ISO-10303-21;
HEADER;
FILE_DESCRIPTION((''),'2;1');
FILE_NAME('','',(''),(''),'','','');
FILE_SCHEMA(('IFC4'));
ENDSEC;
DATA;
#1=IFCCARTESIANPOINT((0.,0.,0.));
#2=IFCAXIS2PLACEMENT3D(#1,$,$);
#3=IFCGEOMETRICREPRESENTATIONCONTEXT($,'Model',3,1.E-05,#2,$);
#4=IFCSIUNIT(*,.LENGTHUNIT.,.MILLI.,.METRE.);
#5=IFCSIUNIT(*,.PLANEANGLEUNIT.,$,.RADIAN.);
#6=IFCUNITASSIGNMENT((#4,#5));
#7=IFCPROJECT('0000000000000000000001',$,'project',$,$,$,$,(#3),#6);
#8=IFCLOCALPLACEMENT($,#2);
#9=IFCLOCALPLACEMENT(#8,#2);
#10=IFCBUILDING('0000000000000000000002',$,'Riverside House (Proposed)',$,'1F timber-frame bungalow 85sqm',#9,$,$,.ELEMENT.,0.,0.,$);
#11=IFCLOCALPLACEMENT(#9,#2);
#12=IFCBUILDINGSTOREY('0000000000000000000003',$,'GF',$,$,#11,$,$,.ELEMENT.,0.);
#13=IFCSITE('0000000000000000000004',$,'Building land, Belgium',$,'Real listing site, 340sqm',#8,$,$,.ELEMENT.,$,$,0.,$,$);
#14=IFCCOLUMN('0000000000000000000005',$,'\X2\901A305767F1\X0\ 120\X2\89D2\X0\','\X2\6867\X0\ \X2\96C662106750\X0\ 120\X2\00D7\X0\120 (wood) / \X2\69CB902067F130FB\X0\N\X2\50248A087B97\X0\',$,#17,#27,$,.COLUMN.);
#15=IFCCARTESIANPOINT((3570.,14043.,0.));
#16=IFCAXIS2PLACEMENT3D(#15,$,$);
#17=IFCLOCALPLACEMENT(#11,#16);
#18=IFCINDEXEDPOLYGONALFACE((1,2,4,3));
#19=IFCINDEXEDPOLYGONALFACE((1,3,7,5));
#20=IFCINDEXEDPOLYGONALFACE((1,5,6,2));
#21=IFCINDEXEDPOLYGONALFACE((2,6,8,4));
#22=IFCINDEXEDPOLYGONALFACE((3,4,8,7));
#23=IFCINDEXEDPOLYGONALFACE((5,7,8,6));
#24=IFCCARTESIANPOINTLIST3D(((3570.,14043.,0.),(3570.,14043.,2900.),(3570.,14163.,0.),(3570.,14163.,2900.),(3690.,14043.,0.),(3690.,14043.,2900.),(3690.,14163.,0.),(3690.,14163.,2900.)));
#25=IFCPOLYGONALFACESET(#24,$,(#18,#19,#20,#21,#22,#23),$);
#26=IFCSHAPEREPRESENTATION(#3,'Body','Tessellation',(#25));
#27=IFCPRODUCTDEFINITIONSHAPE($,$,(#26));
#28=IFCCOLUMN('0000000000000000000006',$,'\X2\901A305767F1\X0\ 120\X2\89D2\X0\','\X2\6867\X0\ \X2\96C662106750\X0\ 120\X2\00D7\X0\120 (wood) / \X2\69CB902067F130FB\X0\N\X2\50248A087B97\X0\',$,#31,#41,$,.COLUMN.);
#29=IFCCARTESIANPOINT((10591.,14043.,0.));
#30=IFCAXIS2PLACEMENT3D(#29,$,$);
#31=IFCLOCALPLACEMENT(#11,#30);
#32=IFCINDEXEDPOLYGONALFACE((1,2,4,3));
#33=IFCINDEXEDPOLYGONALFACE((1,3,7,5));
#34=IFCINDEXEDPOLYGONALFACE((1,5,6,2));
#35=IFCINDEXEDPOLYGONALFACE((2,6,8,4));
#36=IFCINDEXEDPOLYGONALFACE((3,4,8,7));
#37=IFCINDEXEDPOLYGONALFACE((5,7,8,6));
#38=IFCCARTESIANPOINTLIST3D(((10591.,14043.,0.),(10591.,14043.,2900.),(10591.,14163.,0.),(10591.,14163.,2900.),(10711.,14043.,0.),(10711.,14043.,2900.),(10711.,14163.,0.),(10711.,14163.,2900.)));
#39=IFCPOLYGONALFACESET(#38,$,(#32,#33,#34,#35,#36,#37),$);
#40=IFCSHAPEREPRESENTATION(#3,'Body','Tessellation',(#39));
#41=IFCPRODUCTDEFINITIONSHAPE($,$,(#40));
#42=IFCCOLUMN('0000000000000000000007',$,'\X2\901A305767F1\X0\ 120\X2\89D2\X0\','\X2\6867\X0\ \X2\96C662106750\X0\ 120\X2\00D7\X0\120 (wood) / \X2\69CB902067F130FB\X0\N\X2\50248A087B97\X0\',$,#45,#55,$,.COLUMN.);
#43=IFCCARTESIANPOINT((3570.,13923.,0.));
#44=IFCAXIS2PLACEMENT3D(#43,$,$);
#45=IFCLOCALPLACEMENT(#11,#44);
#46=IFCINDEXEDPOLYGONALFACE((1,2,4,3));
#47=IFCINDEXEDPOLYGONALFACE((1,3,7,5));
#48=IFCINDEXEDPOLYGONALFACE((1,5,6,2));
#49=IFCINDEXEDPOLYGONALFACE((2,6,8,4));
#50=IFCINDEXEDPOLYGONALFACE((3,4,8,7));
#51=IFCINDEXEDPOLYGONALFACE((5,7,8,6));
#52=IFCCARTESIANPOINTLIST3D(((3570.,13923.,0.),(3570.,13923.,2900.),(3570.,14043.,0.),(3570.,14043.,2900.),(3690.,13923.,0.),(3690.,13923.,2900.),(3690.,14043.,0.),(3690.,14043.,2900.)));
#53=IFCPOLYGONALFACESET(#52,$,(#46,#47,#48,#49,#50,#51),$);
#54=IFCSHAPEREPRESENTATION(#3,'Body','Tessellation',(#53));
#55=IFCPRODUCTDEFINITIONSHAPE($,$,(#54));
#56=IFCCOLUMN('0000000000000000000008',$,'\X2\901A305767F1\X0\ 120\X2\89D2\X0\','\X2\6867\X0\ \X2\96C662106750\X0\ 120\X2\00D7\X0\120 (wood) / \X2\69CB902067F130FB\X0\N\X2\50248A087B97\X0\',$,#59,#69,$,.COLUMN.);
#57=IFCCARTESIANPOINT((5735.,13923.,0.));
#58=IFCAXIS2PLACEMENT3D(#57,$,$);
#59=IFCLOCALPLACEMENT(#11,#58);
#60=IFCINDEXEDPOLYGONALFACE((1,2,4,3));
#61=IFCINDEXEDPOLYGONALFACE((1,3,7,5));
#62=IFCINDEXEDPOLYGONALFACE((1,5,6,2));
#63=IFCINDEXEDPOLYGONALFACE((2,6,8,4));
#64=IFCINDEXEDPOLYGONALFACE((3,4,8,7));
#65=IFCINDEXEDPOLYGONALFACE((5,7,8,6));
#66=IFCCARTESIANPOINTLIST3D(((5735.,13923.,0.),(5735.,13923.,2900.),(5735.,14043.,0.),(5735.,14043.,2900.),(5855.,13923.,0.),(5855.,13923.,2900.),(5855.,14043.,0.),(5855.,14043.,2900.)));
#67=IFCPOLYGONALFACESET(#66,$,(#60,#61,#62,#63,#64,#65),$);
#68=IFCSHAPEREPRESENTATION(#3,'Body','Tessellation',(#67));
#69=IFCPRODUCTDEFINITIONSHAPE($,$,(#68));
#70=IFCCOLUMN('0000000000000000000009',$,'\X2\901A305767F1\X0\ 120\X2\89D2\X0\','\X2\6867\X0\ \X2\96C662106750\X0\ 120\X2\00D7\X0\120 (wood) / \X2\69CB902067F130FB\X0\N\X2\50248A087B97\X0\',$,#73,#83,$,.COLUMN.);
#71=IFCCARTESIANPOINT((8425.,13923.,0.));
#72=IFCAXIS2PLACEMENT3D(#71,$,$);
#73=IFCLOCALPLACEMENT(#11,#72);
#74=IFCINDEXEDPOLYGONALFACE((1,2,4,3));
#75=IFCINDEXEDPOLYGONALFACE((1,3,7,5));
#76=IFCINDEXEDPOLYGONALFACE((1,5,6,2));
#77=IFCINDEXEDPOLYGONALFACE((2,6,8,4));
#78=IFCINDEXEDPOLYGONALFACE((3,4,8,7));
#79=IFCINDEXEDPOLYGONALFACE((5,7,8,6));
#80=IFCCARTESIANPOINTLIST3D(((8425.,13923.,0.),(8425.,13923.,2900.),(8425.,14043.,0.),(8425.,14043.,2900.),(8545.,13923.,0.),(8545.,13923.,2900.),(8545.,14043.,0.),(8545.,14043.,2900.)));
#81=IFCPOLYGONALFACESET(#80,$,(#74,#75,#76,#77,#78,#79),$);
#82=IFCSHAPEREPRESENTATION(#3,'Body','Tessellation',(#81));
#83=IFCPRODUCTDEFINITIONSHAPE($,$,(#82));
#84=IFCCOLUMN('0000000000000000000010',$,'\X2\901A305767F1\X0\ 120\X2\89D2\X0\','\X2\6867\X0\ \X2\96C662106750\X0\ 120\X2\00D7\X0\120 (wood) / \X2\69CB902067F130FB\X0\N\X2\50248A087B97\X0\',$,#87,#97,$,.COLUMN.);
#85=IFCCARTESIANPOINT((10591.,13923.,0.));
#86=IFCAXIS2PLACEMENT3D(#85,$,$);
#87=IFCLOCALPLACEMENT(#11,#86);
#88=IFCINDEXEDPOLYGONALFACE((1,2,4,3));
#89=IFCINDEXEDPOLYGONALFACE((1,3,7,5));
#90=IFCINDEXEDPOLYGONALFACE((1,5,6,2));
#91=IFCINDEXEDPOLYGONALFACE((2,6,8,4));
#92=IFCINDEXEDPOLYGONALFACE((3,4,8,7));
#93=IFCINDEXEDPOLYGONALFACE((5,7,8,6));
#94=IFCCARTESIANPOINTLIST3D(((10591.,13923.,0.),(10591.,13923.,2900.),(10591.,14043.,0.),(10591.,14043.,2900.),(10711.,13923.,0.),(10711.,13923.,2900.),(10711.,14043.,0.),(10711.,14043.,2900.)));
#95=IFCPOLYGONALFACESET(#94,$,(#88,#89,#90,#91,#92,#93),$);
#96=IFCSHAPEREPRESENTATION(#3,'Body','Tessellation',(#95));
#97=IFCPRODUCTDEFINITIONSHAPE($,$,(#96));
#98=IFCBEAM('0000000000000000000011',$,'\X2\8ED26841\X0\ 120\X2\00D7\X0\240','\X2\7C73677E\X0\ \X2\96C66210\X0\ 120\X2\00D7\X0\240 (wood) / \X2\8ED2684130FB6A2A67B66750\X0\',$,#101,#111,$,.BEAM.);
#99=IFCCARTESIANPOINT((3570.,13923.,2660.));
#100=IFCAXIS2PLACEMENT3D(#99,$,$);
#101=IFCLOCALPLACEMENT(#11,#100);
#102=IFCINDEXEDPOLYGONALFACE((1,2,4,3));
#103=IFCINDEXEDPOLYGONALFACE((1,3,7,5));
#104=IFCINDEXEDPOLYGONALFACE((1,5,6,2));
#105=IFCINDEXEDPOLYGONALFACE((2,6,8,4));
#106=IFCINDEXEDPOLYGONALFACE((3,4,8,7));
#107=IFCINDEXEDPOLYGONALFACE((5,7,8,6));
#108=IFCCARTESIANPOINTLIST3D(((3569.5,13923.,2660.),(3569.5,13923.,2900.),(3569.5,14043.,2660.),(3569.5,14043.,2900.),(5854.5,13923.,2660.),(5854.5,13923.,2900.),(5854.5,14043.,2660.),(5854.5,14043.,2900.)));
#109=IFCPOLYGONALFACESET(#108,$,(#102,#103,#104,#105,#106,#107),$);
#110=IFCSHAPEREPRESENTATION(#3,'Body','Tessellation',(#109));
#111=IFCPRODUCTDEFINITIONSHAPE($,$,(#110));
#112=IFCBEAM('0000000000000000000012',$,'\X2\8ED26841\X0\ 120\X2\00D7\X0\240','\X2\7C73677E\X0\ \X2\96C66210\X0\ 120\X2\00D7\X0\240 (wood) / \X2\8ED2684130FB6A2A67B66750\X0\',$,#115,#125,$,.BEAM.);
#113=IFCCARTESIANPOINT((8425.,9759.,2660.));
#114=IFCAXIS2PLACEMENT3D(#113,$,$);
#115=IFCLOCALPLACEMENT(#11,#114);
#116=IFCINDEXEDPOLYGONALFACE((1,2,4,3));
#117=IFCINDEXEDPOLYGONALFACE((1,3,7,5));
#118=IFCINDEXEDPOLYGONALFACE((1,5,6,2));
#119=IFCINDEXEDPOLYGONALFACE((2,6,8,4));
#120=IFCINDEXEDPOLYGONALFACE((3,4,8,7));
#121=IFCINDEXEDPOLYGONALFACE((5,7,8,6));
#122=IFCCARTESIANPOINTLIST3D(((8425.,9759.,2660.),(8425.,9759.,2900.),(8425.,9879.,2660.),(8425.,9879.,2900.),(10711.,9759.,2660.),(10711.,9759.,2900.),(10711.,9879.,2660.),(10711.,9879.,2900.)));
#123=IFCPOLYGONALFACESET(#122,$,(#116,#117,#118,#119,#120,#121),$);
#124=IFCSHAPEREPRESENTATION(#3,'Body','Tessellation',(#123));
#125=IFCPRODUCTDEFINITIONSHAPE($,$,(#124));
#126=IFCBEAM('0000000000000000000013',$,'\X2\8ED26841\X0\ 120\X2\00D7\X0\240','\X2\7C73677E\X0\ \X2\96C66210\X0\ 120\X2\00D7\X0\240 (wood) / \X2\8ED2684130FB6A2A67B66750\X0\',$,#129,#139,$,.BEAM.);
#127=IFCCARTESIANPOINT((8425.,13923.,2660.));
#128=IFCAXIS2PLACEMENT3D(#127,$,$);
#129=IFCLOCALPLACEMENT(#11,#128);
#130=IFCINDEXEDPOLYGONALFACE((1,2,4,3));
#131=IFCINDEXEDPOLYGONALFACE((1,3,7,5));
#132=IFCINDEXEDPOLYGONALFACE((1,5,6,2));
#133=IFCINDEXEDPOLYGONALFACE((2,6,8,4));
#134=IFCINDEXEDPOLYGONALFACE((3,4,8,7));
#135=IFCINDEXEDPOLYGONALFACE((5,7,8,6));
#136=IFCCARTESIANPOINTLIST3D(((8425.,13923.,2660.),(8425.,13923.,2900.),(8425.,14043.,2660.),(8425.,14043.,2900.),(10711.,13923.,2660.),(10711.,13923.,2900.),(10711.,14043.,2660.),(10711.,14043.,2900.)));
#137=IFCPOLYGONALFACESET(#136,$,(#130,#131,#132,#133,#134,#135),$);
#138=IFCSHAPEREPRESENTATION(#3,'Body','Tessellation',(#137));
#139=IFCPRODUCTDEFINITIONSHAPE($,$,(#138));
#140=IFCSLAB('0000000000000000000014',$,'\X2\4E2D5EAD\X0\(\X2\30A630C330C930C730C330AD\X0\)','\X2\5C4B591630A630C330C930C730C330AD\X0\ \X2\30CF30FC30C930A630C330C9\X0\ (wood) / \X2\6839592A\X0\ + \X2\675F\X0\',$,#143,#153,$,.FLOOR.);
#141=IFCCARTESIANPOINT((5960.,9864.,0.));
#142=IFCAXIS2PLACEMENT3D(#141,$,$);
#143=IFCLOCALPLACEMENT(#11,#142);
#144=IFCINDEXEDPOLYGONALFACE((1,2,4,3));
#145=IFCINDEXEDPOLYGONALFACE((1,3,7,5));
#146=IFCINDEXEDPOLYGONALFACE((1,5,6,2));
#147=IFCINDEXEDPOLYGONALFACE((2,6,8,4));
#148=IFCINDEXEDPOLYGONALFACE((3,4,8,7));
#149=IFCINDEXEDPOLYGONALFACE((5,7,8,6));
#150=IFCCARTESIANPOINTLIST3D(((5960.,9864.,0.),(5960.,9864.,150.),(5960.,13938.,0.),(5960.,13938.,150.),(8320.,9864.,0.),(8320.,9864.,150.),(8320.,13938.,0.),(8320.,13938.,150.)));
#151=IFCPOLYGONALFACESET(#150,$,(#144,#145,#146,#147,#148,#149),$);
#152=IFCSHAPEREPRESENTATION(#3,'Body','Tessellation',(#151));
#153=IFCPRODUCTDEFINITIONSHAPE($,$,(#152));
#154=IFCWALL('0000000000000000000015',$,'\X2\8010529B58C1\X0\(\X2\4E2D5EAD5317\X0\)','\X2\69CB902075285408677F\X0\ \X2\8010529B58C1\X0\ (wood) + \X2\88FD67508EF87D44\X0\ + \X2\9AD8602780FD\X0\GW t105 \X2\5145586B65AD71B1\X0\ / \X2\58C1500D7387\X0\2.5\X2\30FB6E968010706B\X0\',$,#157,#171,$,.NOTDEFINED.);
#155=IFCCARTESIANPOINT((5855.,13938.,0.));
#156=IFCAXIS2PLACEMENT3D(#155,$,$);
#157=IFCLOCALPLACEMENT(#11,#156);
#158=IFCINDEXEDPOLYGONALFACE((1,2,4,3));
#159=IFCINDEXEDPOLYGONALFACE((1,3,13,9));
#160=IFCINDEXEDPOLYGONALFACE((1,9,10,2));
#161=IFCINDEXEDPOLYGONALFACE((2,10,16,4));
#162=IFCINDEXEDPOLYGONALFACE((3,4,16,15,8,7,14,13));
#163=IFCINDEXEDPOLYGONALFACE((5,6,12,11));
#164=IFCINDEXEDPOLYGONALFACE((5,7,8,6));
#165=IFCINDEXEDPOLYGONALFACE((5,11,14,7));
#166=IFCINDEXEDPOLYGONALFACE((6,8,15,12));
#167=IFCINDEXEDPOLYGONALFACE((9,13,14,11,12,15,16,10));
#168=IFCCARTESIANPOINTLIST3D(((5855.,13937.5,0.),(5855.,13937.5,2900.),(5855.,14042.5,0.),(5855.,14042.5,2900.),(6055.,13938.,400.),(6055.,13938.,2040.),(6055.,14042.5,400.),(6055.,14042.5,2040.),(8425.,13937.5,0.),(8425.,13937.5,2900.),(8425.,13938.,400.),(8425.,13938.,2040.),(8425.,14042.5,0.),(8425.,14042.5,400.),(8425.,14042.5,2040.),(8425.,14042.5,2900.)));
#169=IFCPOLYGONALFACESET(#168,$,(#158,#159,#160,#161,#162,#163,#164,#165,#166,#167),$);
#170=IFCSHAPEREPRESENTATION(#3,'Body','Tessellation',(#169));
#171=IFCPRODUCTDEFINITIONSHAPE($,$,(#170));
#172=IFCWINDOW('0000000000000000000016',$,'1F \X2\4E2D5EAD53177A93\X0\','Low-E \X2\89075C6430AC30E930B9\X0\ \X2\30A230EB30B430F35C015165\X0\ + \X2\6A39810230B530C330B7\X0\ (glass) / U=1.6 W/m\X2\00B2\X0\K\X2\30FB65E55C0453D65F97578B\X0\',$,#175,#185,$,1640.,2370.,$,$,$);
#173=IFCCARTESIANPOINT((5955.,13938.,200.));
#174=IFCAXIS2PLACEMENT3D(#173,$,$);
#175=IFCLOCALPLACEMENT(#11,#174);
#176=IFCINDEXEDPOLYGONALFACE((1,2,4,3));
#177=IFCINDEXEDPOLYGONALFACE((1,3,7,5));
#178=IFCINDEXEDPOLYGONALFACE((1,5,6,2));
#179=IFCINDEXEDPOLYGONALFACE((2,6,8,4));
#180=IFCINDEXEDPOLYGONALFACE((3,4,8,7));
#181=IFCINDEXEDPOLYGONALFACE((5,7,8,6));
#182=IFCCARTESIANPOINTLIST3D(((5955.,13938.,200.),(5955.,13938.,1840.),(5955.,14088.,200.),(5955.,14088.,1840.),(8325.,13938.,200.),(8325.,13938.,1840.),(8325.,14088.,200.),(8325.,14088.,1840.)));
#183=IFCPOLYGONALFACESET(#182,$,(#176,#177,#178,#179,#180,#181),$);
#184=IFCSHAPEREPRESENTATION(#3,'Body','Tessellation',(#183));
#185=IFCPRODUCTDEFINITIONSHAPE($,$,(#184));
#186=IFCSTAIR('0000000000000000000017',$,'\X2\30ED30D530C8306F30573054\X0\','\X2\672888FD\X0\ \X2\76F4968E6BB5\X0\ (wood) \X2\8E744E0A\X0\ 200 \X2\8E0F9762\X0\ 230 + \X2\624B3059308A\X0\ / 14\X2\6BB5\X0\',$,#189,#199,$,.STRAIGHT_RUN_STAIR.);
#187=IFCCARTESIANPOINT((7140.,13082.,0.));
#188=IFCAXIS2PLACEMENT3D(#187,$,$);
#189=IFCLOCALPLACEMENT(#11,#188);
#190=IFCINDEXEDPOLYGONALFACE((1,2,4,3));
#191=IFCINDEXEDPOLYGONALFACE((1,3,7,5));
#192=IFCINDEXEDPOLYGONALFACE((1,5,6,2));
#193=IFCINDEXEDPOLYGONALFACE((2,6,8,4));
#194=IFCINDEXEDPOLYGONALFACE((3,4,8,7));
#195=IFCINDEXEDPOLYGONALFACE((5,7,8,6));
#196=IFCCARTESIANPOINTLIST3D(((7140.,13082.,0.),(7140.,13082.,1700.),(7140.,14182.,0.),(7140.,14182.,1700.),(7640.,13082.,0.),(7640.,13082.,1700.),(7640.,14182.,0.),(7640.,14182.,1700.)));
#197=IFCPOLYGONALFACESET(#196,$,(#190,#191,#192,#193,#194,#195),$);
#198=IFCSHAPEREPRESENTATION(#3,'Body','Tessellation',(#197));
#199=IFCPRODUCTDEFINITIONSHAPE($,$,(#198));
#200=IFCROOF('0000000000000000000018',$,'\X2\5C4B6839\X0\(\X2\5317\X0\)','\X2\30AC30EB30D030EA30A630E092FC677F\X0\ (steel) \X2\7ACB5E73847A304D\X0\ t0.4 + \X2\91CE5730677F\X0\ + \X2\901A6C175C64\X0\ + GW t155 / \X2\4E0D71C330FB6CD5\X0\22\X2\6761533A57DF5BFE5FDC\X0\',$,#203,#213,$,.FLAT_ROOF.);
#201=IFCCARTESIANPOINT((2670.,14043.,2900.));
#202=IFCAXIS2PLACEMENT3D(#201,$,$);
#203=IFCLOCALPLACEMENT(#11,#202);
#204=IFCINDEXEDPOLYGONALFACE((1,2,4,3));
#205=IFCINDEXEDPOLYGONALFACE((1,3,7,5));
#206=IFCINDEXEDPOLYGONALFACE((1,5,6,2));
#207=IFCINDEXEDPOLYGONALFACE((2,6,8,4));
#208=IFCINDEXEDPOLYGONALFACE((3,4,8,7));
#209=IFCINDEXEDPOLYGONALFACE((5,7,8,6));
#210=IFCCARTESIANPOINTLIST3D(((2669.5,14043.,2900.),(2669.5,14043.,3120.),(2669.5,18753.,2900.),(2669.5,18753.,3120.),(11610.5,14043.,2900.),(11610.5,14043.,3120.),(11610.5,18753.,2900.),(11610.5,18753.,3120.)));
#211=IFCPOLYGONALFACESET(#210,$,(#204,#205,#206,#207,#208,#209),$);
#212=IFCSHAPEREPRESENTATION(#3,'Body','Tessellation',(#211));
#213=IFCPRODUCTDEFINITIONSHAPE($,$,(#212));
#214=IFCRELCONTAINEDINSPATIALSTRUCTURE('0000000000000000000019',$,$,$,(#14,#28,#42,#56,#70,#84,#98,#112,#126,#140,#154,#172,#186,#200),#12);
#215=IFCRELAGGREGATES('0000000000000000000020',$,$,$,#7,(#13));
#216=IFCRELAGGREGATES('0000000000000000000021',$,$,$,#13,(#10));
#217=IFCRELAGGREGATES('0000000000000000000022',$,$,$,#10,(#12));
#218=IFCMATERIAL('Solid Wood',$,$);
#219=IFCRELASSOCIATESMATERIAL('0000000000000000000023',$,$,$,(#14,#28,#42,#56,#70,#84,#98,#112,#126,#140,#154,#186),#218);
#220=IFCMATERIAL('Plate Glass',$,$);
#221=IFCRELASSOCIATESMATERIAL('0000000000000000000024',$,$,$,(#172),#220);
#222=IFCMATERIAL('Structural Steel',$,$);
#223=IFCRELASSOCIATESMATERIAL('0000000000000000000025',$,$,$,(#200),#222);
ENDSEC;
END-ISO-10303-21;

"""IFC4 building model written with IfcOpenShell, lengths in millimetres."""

from ifc_helpers import new_model, si_unit, frame, frame_2d, origin, place, context, project, spatial, rectangle, extrude, material, element, fill, save


model = new_model("IFC4")

# Units and contexts
model_context = context("Model", 3, precision=1e-05, world=origin())
ifc_project = project(units=[si_unit("LENGTHUNIT", "METRE", prefix="MILLI"), si_unit("PLANEANGLEUNIT", "RADIAN")], contexts=[model_context])

# Site, building, storey
site_placement = place(None, origin())
site = spatial("IfcSite", under=ifc_project, at=site_placement, Name="Building land, Belgium", ObjectType="Real listing site, 340sqm", CompositionType="ELEMENT", RefElevation=0.0)
building_placement = place(site_placement, origin())
building = spatial("IfcBuilding", under=site, at=building_placement, Name="Riverside House (Proposed)", ObjectType="1F timber-frame bungalow 85sqm", CompositionType="ELEMENT", ElevationOfRefHeight=0.0, ElevationOfTerrain=0.0)
storey_placement = place(building_placement, origin())
storey = spatial("IfcBuildingStorey", under=building, at=storey_placement, Name="GF", CompositionType="ELEMENT", Elevation=0.0)

# Columns
ifc_material_1 = material(Name="Solid Wood")
column_1_placement = place(storey_placement, frame((3570.0, 14043.0, 0.0)))
element("IfcColumn", 1, at=column_1_placement, inside=storey, material=ifc_material_1, Name="通し柱 120角", Description="桧 集成材 120×120 (wood) / 構造柱・N値計算", PredefinedType="COLUMN", context=model_context, shape_type="SweptSolid", body=[
    extrude(rectangle(XDim=120.0, YDim=120.0, at=frame_2d((60.0, 60.0))), frame((3570.0, 14043.0, 0.0)), (0.0, 0.0, 1.0), 2900.0),
])
column_2_placement = place(storey_placement, frame((10591.0, 14043.0, 0.0)))
element("IfcColumn", 2, at=column_2_placement, inside=storey, material=ifc_material_1, Name="通し柱 120角", Description="桧 集成材 120×120 (wood) / 構造柱・N値計算", PredefinedType="COLUMN", context=model_context, shape_type="SweptSolid", body=[
    extrude(rectangle(XDim=120.0, YDim=120.0, at=frame_2d((60.0, 60.0))), frame((10591.0, 14043.0, 0.0)), (0.0, 0.0, 1.0), 2900.0),
])
column_3_placement = place(storey_placement, frame((3570.0, 13923.0, 0.0)))
element("IfcColumn", 3, at=column_3_placement, inside=storey, material=ifc_material_1, Name="通し柱 120角", Description="桧 集成材 120×120 (wood) / 構造柱・N値計算", PredefinedType="COLUMN", context=model_context, shape_type="SweptSolid", body=[
    extrude(rectangle(XDim=120.0, YDim=120.0, at=frame_2d((60.0, 60.0))), frame((3570.0, 13923.0, 0.0)), (0.0, 0.0, 1.0), 2900.0),
])
column_4_placement = place(storey_placement, frame((5735.0, 13923.0, 0.0)))
element("IfcColumn", 4, at=column_4_placement, inside=storey, material=ifc_material_1, Name="通し柱 120角", Description="桧 集成材 120×120 (wood) / 構造柱・N値計算", PredefinedType="COLUMN", context=model_context, shape_type="SweptSolid", body=[
    extrude(rectangle(XDim=120.0, YDim=120.0, at=frame_2d((60.0, 60.0))), frame((5735.0, 13923.0, 0.0)), (0.0, 0.0, 1.0), 2900.0),
])
column_5_placement = place(storey_placement, frame((8425.0, 13923.0, 0.0)))
element("IfcColumn", 5, at=column_5_placement, inside=storey, material=ifc_material_1, Name="通し柱 120角", Description="桧 集成材 120×120 (wood) / 構造柱・N値計算", PredefinedType="COLUMN", context=model_context, shape_type="SweptSolid", body=[
    extrude(rectangle(XDim=120.0, YDim=120.0, at=frame_2d((60.0, 60.0))), frame((8425.0, 13923.0, 0.0)), (0.0, 0.0, 1.0), 2900.0),
])
column_6_placement = place(storey_placement, frame((10591.0, 13923.0, 0.0)))
element("IfcColumn", 6, at=column_6_placement, inside=storey, material=ifc_material_1, Name="通し柱 120角", Description="桧 集成材 120×120 (wood) / 構造柱・N値計算", PredefinedType="COLUMN", context=model_context, shape_type="SweptSolid", body=[
    extrude(rectangle(XDim=120.0, YDim=120.0, at=frame_2d((60.0, 60.0))), frame((10591.0, 13923.0, 0.0)), (0.0, 0.0, 1.0), 2900.0),
])

# Beams
beam_1_placement = place(storey_placement, frame((3570.0, 13923.0, 2660.0)))
element("IfcBeam", 7, at=beam_1_placement, inside=storey, material=ifc_material_1, Name="軒桁 120×240", Description="米松 集成 120×240 (wood) / 軒桁・横架材", PredefinedType="BEAM", context=model_context, shape_type="SweptSolid", body=[
    extrude(rectangle(XDim=2285.0, YDim=120.0, at=frame_2d((1142.0, 60.0))), frame((3570.0, 13923.0, 2660.0)), (0.0, 0.0, 1.0), 240.0),
])
beam_2_placement = place(storey_placement, frame((8425.0, 9759.0, 2660.0)))
element("IfcBeam", 8, at=beam_2_placement, inside=storey, material=ifc_material_1, Name="軒桁 120×240", Description="米松 集成 120×240 (wood) / 軒桁・横架材", PredefinedType="BEAM", context=model_context, shape_type="SweptSolid", body=[
    extrude(rectangle(XDim=2286.0, YDim=120.0, at=frame_2d((1143.0, 60.0))), frame((8425.0, 9759.0, 2660.0)), (0.0, 0.0, 1.0), 240.0),
])
beam_3_placement = place(storey_placement, frame((8425.0, 13923.0, 2660.0)))
element("IfcBeam", 9, at=beam_3_placement, inside=storey, material=ifc_material_1, Name="軒桁 120×240", Description="米松 集成 120×240 (wood) / 軒桁・横架材", PredefinedType="BEAM", context=model_context, shape_type="SweptSolid", body=[
    extrude(rectangle(XDim=2286.0, YDim=120.0, at=frame_2d((1143.0, 60.0))), frame((8425.0, 13923.0, 2660.0)), (0.0, 0.0, 1.0), 240.0),
])

# Slab
slab_1_placement = place(storey_placement, frame((5960.0, 9864.0, 0.0)))
element("IfcSlab", 10, at=slab_1_placement, inside=storey, material=ifc_material_1, Name="中庭(ウッドデッキ)", Description="屋外ウッドデッキ ハードウッド (wood) / 根太 + 束", PredefinedType="FLOOR", context=model_context, shape_type="SweptSolid", body=[
    extrude(rectangle(XDim=2360.0, YDim=4074.0, at=frame_2d((1180.0, 2037.0))), frame((5960.0, 9864.0, 0.0)), (0.0, 0.0, 1.0), 150.0),
])

# Wall, opening, window
wall_placement = place(storey_placement, frame((5855.0, 13938.0, 0.0)))
wall = element("IfcWall", 11, at=wall_placement, inside=storey, material=ifc_material_1, Name="耐力壁(中庭北)", Description="構造用合板 耐力壁 (wood) + 製材軸組 + 高性能GW t105 充填断熱 / 壁倍率2.5・準耐火", PredefinedType="NOTDEFINED", context=model_context, shape_type="SweptSolid", body=[
    extrude(rectangle(XDim=2570.0, YDim=105.0, at=frame_2d((1285.0, 52.0))), frame((5855.0, 13938.0, 0.0)), (0.0, 0.0, 1.0), 2900.0),
])
opening_placement = place(storey_placement, frame((5955.0, 13938.0, 200.0)))
opening = element("IfcOpeningElement", 12, at=opening_placement, cuts=wall, PredefinedType="NOTDEFINED", context=model_context, shape_type="SweptSolid", body=[
    extrude(rectangle(XDim=2370.0, YDim=150.0, at=frame_2d((1185.0, 75.0))), frame((5955.0, 13938.0, 200.0)), (0.0, 0.0, 1.0), 1640.0),
])
ifc_material_2 = material(Name="Plate Glass")
window_placement = place(storey_placement, frame((5955.0, 13938.0, 200.0)))
window = element("IfcWindow", 13, at=window_placement, inside=storey, material=ifc_material_2, Name="1F 中庭北窓", Description="Low-E 複層ガラス アルゴン封入 + 樹脂サッシ (glass) / U=1.6 W/m²K・日射取得型", OverallHeight=1640.0, OverallWidth=2370.0, context=model_context, shape_type="SweptSolid", body=[
    extrude(rectangle(XDim=2370.0, YDim=150.0, at=frame_2d((1185.0, 75.0))), frame((5955.0, 13938.0, 200.0)), (0.0, 0.0, 1.0), 1640.0),
])
fill(opening, window)

# Stair
stair_placement = place(storey_placement, frame((7140.0, 13082.0, 0.0)))
element("IfcStair", 14, at=stair_placement, inside=storey, material=ifc_material_1, Name="ロフトはしご", Description="木製 直階段 (wood) 蹴上 200 踏面 230 + 手すり / 14段", PredefinedType="STRAIGHT_RUN_STAIR", context=model_context, shape_type="SweptSolid", body=[
    extrude(rectangle(XDim=500.0, YDim=1100.0, at=frame_2d((250.0, 550.0))), frame((7140.0, 13082.0, 0.0)), (0.0, 0.0, 1.0), 1700.0),
])

# Roof
ifc_material_3 = material(Name="Structural Steel")
roof_placement = place(storey_placement, frame((2670.0, 14043.0, 2900.0)))
element("IfcRoof", 15, at=roof_placement, inside=storey, material=ifc_material_3, Name="屋根(北)", Description="ガルバリウム鋼板 (steel) 立平葺き t0.4 + 野地板 + 通気層 + GW t155 / 不燃・法22条区域対応", PredefinedType="FLAT_ROOF", context=model_context, shape_type="SweptSolid", body=[
    extrude(rectangle(XDim=8941.0, YDim=4710.0, at=frame_2d((4470.0, 2355.0))), frame((2670.0, 14043.0, 2900.0)), (0.0, 0.0, 1.0), 220.0),
])

save(model, "model.ifc")
